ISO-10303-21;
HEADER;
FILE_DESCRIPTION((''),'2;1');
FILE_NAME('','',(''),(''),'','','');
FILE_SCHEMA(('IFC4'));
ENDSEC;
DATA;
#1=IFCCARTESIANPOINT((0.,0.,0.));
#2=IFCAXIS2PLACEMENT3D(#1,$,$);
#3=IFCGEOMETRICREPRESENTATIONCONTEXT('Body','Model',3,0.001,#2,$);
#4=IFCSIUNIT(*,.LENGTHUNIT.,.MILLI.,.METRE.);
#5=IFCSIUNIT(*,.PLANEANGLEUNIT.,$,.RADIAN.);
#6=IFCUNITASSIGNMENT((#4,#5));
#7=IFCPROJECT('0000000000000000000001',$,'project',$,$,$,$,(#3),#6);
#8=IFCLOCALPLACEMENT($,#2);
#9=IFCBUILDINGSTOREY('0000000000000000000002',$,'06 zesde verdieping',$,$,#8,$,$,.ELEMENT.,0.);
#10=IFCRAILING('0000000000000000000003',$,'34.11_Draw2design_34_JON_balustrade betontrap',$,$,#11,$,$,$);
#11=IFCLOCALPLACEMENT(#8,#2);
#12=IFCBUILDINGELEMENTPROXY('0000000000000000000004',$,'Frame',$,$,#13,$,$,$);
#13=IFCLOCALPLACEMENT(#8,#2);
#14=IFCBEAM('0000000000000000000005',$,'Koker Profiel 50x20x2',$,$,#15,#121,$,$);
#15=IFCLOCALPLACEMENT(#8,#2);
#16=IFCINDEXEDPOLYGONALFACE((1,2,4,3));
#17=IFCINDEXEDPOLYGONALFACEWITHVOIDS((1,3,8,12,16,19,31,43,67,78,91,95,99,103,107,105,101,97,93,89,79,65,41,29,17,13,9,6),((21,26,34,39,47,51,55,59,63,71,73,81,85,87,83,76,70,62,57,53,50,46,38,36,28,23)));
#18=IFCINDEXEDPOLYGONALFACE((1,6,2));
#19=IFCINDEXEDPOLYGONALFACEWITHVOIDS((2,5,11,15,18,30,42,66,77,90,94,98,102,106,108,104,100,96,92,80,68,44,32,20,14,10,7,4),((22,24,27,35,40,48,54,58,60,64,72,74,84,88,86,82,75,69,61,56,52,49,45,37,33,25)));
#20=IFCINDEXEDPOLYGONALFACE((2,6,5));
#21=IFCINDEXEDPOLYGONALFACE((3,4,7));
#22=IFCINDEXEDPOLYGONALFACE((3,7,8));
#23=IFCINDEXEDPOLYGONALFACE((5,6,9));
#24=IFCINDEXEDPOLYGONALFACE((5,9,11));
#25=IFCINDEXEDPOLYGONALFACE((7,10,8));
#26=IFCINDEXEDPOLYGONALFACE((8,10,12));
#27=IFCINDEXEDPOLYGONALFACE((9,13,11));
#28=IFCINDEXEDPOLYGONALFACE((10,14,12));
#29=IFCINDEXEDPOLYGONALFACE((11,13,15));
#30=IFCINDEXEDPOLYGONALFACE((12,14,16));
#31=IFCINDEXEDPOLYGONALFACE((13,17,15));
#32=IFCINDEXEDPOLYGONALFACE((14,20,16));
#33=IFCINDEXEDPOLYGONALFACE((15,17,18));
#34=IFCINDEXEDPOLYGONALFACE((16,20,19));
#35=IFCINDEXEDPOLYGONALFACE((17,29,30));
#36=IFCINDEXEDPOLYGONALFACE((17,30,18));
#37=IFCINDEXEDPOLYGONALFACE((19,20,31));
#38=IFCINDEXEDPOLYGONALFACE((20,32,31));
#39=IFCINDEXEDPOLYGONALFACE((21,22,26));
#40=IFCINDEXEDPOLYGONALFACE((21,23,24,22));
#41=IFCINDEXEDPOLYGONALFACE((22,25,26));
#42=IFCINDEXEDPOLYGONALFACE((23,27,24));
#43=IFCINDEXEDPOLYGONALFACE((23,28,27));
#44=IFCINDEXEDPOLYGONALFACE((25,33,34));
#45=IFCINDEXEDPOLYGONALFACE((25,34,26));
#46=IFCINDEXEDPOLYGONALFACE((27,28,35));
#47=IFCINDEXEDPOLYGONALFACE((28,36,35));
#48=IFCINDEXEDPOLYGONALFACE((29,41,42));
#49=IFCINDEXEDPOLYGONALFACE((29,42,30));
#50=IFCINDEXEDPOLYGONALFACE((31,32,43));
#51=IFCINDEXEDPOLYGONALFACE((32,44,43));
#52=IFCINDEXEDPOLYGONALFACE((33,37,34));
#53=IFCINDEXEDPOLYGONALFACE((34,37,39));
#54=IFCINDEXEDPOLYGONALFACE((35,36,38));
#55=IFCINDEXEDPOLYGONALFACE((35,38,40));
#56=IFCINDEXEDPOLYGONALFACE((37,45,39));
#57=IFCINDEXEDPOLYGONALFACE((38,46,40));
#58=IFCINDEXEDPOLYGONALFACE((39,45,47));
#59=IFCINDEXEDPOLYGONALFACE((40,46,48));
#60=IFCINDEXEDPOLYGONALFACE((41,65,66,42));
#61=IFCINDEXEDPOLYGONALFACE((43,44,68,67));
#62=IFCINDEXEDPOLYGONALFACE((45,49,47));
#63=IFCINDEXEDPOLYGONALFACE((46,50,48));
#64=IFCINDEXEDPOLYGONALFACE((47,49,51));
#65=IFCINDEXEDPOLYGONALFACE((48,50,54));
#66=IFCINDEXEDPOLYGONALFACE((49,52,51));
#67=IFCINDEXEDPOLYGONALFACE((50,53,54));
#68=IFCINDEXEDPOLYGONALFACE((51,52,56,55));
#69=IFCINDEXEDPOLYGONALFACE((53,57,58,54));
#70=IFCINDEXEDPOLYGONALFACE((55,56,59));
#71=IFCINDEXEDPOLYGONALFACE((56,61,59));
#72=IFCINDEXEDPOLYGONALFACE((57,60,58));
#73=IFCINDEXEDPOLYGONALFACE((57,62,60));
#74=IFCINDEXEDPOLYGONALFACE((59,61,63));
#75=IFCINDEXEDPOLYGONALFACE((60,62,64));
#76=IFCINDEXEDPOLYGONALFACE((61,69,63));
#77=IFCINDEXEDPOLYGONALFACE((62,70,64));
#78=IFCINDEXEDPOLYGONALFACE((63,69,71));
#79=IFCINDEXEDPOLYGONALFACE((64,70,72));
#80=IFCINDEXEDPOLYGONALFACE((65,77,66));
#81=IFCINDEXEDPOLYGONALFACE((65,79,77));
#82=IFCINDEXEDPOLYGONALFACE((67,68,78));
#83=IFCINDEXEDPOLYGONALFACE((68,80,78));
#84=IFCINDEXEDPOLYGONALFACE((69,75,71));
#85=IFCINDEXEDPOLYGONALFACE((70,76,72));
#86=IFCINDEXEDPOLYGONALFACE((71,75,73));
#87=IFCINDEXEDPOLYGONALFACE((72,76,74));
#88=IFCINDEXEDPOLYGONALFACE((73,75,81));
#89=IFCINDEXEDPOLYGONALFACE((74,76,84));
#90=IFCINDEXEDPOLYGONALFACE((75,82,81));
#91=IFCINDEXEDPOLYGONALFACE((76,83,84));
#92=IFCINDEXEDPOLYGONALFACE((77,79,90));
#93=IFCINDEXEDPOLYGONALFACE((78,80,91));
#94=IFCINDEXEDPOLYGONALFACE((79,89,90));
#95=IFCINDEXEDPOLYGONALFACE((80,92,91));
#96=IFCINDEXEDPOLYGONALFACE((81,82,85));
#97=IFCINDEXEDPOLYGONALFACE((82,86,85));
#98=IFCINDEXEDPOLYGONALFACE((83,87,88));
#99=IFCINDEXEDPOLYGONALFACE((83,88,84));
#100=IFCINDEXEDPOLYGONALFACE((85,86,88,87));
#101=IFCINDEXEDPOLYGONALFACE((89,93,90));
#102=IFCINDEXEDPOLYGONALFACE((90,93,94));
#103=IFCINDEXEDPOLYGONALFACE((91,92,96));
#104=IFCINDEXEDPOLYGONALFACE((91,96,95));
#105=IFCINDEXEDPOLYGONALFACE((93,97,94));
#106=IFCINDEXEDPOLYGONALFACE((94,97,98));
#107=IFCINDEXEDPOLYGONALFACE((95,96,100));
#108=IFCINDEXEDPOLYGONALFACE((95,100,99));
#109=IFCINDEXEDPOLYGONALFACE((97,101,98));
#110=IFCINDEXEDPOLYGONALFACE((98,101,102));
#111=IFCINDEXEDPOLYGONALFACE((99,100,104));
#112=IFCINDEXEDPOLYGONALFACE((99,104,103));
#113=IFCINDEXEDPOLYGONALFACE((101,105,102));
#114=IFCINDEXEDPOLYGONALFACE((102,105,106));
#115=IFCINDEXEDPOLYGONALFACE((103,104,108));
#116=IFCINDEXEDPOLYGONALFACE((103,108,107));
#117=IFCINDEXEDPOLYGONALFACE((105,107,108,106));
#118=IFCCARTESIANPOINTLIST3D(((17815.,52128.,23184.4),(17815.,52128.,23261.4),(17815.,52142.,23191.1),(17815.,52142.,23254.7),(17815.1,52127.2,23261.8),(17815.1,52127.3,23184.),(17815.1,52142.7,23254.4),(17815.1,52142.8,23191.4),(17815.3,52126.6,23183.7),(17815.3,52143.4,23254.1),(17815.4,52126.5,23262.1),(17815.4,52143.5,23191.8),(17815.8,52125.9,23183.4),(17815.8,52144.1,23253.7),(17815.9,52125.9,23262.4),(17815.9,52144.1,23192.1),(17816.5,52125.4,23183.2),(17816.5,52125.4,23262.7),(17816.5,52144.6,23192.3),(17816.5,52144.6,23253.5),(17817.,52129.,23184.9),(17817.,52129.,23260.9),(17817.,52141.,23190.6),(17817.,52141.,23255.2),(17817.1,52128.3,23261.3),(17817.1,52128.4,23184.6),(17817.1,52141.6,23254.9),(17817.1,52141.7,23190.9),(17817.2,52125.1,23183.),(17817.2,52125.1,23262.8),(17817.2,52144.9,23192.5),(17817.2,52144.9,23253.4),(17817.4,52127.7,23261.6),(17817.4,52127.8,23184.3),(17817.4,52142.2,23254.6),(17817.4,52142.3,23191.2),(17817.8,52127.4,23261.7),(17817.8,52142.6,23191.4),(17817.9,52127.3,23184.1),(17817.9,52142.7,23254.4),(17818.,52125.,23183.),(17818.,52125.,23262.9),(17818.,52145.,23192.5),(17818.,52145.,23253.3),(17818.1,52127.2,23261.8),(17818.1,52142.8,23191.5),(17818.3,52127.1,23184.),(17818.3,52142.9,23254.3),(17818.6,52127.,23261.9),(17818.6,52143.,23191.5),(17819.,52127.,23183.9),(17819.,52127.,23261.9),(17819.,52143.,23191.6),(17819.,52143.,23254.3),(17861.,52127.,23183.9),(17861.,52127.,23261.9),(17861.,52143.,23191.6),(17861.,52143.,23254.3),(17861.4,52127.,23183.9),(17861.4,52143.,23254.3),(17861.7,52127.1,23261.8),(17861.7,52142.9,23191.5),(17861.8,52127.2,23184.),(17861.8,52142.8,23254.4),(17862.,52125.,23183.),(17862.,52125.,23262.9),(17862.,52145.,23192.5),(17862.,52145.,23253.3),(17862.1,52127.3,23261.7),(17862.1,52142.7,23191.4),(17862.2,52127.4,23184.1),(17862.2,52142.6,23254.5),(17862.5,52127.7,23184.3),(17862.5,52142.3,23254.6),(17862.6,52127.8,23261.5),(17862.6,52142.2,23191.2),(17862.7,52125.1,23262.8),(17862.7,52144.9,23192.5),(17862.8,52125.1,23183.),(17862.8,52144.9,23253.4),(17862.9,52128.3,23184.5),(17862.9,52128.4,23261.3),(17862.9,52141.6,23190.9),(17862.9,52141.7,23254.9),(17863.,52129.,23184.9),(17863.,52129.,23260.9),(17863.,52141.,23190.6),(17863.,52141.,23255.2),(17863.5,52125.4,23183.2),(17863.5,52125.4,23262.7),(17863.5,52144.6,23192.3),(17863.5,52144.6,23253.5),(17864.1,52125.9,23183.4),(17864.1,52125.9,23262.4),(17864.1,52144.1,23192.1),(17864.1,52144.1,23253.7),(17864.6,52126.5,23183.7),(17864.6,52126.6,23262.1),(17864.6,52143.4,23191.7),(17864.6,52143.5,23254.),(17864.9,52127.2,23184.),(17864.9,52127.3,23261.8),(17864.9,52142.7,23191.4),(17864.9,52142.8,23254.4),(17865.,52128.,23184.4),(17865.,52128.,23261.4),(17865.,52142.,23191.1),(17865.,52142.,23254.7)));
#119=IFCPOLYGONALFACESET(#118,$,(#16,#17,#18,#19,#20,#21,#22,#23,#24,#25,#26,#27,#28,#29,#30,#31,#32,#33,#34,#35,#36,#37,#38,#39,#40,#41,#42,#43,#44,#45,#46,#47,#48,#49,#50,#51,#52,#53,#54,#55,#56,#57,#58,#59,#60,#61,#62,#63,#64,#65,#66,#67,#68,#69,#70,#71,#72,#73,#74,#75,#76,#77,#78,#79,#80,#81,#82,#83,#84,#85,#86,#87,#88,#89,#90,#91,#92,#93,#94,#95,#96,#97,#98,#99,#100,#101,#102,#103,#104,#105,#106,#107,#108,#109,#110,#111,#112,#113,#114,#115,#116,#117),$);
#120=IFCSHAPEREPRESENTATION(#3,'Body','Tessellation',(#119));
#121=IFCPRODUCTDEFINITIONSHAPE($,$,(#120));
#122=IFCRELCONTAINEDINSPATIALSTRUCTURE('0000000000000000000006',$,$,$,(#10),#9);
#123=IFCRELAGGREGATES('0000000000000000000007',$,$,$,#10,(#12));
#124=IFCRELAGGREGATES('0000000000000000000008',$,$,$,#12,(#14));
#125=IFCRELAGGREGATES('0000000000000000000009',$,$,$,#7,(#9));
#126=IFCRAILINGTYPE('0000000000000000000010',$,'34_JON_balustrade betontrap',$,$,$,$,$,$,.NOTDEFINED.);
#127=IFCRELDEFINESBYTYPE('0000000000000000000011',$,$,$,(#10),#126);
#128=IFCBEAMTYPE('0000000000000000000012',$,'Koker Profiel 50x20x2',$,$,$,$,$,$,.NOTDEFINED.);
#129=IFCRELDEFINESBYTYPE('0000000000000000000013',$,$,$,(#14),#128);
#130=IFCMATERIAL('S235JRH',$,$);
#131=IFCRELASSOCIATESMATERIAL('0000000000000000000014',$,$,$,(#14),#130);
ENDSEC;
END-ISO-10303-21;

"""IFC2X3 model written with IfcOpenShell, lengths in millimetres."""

from ifc_helpers import new_model, si_unit, frame, origin, origin_2d, place, context, project, spatial, hollow_rectangle, extrude, clip, halfspace, source, transform, mapped, material, type_object, element, aggregate, save


model = new_model("IFC2X3")

# Units and contexts
model_context = context("Model", 3, precision=0.001, world=origin(), identifier="Body")
ifc_project = project(units=[si_unit("LENGTHUNIT", "METRE", prefix="MILLI"), si_unit("PLANEANGLEUNIT", "RADIAN")], contexts=[model_context])

# Storey
storey_placement = place(None, origin())
storey = spatial("IfcBuildingStorey", under=ifc_project, at=storey_placement, Name="06 zesde verdieping", CompositionType="ELEMENT", Elevation=0.0)

# Shared definitions
railing_type_1 = type_object("IfcRailingType", Name="34_JON_balustrade betontrap")
ifc_material_1 = material(Name="S235JRH")
beam_type_1 = type_object("IfcBeamType", Name="Koker Profiel 50x20x2")

# Railing, building element proxy
railing_1_placement = place(storey_placement, frame((38619.5, 98107.5, -25701.4), z_axis=(0.0, 0.0, 1.0), x_axis=(-1.0, 0.0, 0.0)))
railing_1 = element("IfcRailing", 1, at=railing_1_placement, inside=storey, type_object=railing_type_1, Name="34.11_Draw2design_34_JON_balustrade betontrap")
proxy_1_placement = place(railing_1_placement, origin())
proxy_1 = element("IfcBuildingElementProxy", 2, at=proxy_1_placement, Name="Frame")
aggregate(railing_1, [proxy_1])

# Beam
shared_shape_1 = source(origin(), model_context, "Body", "Clipping", [
    clip(clip(extrude(hollow_rectangle(XDim=20.0, YDim=50.0, WallThickness=2.0, InnerFilletRadius=2.0, OuterFilletRadius=3.0, at=origin_2d()), origin(), (0.0, 0.0, -1.0), 79.9), halfspace(frame((-10.0, 25.0, -9.6), z_axis=(-0.430948, 0.0, 0.902377), x_axis=(0.902377, 0.0, 0.430948)), False)), halfspace(frame((-10.0, -25.0, -70.3), z_axis=(-0.430948, 0.0, -0.902377), x_axis=(-0.902377, 0.0, 0.430948)), False)),
])
beam_1_placement = place(proxy_1_placement, frame((20779.5, 45972.5, 48964.2), z_axis=(0.0, 0.0, 1.0), x_axis=(0.0, 1.0, 0.0)))
beam_1 = element("IfcBeam", 3, at=beam_1_placement, type_object=beam_type_1, material=ifc_material_1, Name="Koker Profiel 50x20x2", context=model_context, shape_type="MappedRepresentation", body=[
    mapped(shared_shape_1, transform((0.0, 0.0, 0.0), scale=1.0)),
])
aggregate(proxy_1, [beam_1])

save(model, "model.ifc")
